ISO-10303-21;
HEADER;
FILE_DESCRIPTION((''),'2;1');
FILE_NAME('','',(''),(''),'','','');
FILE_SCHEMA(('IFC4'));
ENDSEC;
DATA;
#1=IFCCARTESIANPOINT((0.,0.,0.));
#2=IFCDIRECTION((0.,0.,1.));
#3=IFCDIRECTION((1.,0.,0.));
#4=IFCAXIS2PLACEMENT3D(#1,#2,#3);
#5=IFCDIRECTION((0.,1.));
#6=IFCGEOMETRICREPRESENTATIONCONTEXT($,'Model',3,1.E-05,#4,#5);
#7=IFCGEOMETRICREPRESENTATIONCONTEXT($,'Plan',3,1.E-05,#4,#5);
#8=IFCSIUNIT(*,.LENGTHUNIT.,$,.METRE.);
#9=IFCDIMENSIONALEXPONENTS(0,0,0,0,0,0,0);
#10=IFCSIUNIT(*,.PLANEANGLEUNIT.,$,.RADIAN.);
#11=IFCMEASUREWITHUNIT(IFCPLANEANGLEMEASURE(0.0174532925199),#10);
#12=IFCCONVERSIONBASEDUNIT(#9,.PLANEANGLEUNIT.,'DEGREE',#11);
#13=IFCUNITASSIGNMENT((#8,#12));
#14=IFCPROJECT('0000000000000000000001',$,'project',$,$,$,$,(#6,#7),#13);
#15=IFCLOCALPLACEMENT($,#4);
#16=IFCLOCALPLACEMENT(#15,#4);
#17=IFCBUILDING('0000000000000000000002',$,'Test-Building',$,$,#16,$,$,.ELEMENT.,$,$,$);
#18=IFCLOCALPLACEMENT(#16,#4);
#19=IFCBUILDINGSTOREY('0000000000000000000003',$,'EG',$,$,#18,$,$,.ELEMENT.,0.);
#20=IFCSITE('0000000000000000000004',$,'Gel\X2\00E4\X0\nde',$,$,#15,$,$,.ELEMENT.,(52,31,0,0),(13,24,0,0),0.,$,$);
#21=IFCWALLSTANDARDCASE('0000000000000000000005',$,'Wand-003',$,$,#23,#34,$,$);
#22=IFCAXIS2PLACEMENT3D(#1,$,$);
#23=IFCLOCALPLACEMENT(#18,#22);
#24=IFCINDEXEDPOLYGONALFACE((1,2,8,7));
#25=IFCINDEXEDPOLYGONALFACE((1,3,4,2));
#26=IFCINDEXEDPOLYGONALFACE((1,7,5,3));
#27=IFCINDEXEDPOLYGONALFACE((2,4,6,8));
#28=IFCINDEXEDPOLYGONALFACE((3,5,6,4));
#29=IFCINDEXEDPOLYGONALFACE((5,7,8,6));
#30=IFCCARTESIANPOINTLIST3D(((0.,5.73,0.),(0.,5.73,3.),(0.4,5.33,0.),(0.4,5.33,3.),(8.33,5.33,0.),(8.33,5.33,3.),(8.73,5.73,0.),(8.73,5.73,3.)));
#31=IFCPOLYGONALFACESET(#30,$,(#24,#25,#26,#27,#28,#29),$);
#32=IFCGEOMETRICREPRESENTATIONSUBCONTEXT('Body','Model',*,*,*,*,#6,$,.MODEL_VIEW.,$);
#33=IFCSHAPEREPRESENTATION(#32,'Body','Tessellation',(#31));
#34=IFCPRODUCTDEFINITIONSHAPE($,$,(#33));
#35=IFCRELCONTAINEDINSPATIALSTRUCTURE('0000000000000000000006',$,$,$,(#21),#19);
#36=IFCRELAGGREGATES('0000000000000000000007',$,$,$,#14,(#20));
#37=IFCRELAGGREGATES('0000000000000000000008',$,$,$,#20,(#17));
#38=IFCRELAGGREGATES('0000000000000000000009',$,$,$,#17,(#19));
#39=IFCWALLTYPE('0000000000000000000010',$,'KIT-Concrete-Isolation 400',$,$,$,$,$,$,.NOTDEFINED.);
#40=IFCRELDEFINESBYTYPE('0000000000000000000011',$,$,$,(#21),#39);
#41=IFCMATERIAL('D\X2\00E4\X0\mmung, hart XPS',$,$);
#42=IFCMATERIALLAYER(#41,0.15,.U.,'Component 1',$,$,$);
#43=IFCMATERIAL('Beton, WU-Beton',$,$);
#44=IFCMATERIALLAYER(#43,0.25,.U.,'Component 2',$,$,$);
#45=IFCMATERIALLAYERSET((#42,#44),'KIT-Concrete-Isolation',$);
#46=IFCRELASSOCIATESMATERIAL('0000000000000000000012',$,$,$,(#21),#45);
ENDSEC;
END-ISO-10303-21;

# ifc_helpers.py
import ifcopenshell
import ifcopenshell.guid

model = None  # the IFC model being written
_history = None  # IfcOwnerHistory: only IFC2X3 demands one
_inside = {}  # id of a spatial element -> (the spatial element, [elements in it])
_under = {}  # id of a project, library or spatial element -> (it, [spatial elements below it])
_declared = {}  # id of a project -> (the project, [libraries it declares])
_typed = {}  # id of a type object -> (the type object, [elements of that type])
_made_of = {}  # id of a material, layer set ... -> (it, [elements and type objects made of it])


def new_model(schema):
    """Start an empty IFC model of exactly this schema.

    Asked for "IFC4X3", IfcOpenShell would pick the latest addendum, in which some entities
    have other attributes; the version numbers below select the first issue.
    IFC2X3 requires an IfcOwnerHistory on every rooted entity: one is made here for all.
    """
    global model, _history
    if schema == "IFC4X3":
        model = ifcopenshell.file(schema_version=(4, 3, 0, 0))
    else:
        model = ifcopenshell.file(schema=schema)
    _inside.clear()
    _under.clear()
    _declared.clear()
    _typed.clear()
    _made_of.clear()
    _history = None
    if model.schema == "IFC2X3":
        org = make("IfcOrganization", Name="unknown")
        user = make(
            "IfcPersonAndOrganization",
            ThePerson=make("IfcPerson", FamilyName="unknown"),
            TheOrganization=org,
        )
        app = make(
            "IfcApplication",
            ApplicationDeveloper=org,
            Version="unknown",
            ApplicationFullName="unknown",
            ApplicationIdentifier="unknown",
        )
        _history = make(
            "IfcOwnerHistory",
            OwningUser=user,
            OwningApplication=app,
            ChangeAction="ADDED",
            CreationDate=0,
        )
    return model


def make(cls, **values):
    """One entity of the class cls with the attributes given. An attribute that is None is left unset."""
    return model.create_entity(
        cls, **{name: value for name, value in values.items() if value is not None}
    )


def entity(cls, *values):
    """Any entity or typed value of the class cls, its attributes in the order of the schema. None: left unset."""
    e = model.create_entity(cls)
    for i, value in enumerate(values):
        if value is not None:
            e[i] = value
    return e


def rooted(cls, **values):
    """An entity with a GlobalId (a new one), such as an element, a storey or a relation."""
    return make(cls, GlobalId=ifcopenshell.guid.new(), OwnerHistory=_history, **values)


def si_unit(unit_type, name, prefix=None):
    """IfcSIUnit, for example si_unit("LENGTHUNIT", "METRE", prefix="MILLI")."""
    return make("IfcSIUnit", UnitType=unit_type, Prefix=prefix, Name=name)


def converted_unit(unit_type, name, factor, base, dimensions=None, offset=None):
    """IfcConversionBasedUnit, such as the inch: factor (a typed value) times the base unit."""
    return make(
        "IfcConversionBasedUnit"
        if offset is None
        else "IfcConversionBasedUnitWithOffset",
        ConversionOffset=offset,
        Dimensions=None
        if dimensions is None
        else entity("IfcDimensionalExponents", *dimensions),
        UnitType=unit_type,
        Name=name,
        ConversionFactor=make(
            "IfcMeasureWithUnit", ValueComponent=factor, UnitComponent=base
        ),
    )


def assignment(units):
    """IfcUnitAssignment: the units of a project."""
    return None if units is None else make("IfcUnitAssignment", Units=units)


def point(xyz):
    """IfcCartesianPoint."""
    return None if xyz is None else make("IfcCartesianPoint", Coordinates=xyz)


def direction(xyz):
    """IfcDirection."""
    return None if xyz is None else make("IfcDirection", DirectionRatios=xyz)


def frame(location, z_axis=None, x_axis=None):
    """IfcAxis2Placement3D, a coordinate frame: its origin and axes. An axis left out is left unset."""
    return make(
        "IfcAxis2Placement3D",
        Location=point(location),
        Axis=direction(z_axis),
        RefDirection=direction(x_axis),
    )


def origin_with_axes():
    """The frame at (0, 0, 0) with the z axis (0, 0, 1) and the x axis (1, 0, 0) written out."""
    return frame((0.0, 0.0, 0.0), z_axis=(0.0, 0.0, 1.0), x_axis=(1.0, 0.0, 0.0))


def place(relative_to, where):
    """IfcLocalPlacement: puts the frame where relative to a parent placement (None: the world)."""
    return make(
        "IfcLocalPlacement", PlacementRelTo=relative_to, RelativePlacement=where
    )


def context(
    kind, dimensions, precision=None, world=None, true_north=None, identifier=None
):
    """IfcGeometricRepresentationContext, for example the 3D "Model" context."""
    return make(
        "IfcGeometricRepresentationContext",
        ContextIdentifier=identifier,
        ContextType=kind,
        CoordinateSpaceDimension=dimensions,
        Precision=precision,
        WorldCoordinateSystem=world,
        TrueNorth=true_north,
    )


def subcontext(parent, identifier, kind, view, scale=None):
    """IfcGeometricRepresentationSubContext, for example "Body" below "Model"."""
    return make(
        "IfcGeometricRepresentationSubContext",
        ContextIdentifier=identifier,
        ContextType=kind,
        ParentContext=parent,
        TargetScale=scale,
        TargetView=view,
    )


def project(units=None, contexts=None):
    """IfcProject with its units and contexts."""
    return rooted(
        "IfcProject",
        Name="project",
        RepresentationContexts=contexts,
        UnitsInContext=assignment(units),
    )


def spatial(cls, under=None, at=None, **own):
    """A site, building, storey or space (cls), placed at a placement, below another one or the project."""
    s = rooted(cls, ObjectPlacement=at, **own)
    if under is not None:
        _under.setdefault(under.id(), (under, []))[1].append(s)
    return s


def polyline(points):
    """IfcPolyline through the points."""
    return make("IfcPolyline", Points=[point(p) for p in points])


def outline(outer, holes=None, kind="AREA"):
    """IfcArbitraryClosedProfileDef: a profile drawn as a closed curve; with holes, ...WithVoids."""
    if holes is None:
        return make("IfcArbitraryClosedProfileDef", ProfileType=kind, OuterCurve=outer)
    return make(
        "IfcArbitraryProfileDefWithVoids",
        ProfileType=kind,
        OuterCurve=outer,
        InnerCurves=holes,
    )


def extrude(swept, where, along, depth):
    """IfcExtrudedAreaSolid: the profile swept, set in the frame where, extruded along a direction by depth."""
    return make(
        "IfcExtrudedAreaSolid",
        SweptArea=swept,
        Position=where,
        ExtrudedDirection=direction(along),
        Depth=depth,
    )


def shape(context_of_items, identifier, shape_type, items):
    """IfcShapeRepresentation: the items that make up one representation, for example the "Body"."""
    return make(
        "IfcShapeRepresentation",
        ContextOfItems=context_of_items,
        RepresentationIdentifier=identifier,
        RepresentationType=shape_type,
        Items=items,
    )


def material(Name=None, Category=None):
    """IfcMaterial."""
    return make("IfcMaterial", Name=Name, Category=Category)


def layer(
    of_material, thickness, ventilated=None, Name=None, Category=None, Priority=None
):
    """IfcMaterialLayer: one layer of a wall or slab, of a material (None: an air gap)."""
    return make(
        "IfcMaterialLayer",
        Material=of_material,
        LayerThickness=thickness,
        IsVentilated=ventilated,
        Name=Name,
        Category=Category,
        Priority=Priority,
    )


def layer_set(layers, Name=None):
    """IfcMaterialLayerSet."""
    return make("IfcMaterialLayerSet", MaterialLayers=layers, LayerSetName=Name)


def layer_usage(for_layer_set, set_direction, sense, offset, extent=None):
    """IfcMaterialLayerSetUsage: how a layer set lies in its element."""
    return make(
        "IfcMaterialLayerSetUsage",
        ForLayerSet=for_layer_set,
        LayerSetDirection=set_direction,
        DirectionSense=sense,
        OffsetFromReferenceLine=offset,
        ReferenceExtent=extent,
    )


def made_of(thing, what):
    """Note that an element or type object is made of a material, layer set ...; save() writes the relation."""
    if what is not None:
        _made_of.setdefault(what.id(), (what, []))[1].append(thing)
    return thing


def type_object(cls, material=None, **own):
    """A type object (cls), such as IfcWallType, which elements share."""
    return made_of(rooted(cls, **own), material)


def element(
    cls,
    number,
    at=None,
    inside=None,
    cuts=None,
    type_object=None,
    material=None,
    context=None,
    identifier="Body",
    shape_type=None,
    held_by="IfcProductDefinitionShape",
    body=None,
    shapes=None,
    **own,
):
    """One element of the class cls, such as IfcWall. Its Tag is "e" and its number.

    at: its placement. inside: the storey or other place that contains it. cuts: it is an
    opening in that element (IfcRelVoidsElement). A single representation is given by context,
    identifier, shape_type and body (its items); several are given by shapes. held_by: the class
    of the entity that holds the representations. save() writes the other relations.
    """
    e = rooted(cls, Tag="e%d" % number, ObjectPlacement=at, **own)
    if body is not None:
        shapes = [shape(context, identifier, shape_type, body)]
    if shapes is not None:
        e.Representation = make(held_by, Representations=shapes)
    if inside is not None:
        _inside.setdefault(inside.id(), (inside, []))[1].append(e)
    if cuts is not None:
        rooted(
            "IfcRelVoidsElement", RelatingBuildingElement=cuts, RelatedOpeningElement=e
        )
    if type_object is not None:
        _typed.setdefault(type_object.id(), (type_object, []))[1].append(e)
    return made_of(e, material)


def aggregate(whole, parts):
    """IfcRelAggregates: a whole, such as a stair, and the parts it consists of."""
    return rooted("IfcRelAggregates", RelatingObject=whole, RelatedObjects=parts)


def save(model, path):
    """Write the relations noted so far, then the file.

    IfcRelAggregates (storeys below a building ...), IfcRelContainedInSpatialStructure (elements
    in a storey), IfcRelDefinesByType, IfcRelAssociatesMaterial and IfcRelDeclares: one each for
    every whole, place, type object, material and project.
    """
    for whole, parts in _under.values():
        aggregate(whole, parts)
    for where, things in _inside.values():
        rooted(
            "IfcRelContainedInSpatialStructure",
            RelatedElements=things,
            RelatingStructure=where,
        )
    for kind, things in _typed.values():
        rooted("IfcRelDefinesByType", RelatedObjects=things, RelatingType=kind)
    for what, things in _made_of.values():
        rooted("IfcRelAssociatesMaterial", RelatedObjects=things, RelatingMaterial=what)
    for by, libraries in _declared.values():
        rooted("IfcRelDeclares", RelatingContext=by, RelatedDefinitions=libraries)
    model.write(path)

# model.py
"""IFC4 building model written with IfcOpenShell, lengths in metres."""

from ifc_helpers import new_model, entity, si_unit, converted_unit, direction, frame, origin_with_axes, place, context, subcontext, project, spatial, polyline, outline, extrude, material, layer, layer_set, layer_usage, type_object, element, save


model = new_model("IFC4")

# Units and contexts
model_context = context("Model", 3, precision=1e-05, world=origin_with_axes(), true_north=direction((0.0, 1.0)))
plan_context = context("Plan", 3, precision=1e-05, world=origin_with_axes(), true_north=direction((0.0, 1.0)))
body_context = subcontext(model_context, "Body", "Model", "MODEL_VIEW")
ifc_project = project(units=[si_unit("LENGTHUNIT", "METRE"), converted_unit("PLANEANGLEUNIT", "DEGREE", entity("IfcPlaneAngleMeasure", 0.0174532925199), si_unit("PLANEANGLEUNIT", "RADIAN"), dimensions=[0, 0, 0, 0, 0, 0, 0])], contexts=[model_context, plan_context])

# Site, building, storey
site_placement = place(None, origin_with_axes())
site = spatial("IfcSite", under=ifc_project, at=site_placement, Name="Gelände", CompositionType="ELEMENT", RefLatitude=(52, 31, 0, 0), RefLongitude=(13, 24, 0, 0), RefElevation=0.0)
building_placement = place(site_placement, origin_with_axes())
building = spatial("IfcBuilding", under=site, at=building_placement, Name="Test-Building", CompositionType="ELEMENT")
storey_placement = place(building_placement, origin_with_axes())
storey = spatial("IfcBuildingStorey", under=building, at=storey_placement, Name="EG", CompositionType="ELEMENT", Elevation=0.0)

# Wall
ifc_material_1 = material(Name="Dämmung, hart XPS")
ifc_layer_1 = layer(ifc_material_1, 0.15, ventilated="UNKNOWN", Name="Component 1")
ifc_material_2 = material(Name="Beton, WU-Beton")
ifc_layer_2 = layer(ifc_material_2, 0.25, ventilated="UNKNOWN", Name="Component 2")
ifc_layer_set = layer_set([ifc_layer_1, ifc_layer_2], Name="KIT-Concrete-Isolation")
ifc_layer_usage = layer_usage(ifc_layer_set, "AXIS2", "NEGATIVE", 0.0)
wall_type = type_object("IfcWallType", Name="KIT-Concrete-Isolation 400", PredefinedType="NOTDEFINED")
wall_placement = place(storey_placement, frame((0.0, 5.73, 0.0), z_axis=(0.0, 0.0, 1.0), x_axis=(1.0, 0.0, 0.0)))
element("IfcWallStandardCase", 1, at=wall_placement, inside=storey, type_object=wall_type, material=ifc_layer_usage, Name="Wand-003", context=body_context, shape_type="SweptSolid", body=[
    extrude(outline(polyline([(0.4, -0.4), (8.33, -0.4), (8.73, 0.0), (0.0, 0.0), (0.4, -0.4)])), origin_with_axes(), (0.0, 0.0, 1.0), 3.0),
])

save(model, "model.ifc")
